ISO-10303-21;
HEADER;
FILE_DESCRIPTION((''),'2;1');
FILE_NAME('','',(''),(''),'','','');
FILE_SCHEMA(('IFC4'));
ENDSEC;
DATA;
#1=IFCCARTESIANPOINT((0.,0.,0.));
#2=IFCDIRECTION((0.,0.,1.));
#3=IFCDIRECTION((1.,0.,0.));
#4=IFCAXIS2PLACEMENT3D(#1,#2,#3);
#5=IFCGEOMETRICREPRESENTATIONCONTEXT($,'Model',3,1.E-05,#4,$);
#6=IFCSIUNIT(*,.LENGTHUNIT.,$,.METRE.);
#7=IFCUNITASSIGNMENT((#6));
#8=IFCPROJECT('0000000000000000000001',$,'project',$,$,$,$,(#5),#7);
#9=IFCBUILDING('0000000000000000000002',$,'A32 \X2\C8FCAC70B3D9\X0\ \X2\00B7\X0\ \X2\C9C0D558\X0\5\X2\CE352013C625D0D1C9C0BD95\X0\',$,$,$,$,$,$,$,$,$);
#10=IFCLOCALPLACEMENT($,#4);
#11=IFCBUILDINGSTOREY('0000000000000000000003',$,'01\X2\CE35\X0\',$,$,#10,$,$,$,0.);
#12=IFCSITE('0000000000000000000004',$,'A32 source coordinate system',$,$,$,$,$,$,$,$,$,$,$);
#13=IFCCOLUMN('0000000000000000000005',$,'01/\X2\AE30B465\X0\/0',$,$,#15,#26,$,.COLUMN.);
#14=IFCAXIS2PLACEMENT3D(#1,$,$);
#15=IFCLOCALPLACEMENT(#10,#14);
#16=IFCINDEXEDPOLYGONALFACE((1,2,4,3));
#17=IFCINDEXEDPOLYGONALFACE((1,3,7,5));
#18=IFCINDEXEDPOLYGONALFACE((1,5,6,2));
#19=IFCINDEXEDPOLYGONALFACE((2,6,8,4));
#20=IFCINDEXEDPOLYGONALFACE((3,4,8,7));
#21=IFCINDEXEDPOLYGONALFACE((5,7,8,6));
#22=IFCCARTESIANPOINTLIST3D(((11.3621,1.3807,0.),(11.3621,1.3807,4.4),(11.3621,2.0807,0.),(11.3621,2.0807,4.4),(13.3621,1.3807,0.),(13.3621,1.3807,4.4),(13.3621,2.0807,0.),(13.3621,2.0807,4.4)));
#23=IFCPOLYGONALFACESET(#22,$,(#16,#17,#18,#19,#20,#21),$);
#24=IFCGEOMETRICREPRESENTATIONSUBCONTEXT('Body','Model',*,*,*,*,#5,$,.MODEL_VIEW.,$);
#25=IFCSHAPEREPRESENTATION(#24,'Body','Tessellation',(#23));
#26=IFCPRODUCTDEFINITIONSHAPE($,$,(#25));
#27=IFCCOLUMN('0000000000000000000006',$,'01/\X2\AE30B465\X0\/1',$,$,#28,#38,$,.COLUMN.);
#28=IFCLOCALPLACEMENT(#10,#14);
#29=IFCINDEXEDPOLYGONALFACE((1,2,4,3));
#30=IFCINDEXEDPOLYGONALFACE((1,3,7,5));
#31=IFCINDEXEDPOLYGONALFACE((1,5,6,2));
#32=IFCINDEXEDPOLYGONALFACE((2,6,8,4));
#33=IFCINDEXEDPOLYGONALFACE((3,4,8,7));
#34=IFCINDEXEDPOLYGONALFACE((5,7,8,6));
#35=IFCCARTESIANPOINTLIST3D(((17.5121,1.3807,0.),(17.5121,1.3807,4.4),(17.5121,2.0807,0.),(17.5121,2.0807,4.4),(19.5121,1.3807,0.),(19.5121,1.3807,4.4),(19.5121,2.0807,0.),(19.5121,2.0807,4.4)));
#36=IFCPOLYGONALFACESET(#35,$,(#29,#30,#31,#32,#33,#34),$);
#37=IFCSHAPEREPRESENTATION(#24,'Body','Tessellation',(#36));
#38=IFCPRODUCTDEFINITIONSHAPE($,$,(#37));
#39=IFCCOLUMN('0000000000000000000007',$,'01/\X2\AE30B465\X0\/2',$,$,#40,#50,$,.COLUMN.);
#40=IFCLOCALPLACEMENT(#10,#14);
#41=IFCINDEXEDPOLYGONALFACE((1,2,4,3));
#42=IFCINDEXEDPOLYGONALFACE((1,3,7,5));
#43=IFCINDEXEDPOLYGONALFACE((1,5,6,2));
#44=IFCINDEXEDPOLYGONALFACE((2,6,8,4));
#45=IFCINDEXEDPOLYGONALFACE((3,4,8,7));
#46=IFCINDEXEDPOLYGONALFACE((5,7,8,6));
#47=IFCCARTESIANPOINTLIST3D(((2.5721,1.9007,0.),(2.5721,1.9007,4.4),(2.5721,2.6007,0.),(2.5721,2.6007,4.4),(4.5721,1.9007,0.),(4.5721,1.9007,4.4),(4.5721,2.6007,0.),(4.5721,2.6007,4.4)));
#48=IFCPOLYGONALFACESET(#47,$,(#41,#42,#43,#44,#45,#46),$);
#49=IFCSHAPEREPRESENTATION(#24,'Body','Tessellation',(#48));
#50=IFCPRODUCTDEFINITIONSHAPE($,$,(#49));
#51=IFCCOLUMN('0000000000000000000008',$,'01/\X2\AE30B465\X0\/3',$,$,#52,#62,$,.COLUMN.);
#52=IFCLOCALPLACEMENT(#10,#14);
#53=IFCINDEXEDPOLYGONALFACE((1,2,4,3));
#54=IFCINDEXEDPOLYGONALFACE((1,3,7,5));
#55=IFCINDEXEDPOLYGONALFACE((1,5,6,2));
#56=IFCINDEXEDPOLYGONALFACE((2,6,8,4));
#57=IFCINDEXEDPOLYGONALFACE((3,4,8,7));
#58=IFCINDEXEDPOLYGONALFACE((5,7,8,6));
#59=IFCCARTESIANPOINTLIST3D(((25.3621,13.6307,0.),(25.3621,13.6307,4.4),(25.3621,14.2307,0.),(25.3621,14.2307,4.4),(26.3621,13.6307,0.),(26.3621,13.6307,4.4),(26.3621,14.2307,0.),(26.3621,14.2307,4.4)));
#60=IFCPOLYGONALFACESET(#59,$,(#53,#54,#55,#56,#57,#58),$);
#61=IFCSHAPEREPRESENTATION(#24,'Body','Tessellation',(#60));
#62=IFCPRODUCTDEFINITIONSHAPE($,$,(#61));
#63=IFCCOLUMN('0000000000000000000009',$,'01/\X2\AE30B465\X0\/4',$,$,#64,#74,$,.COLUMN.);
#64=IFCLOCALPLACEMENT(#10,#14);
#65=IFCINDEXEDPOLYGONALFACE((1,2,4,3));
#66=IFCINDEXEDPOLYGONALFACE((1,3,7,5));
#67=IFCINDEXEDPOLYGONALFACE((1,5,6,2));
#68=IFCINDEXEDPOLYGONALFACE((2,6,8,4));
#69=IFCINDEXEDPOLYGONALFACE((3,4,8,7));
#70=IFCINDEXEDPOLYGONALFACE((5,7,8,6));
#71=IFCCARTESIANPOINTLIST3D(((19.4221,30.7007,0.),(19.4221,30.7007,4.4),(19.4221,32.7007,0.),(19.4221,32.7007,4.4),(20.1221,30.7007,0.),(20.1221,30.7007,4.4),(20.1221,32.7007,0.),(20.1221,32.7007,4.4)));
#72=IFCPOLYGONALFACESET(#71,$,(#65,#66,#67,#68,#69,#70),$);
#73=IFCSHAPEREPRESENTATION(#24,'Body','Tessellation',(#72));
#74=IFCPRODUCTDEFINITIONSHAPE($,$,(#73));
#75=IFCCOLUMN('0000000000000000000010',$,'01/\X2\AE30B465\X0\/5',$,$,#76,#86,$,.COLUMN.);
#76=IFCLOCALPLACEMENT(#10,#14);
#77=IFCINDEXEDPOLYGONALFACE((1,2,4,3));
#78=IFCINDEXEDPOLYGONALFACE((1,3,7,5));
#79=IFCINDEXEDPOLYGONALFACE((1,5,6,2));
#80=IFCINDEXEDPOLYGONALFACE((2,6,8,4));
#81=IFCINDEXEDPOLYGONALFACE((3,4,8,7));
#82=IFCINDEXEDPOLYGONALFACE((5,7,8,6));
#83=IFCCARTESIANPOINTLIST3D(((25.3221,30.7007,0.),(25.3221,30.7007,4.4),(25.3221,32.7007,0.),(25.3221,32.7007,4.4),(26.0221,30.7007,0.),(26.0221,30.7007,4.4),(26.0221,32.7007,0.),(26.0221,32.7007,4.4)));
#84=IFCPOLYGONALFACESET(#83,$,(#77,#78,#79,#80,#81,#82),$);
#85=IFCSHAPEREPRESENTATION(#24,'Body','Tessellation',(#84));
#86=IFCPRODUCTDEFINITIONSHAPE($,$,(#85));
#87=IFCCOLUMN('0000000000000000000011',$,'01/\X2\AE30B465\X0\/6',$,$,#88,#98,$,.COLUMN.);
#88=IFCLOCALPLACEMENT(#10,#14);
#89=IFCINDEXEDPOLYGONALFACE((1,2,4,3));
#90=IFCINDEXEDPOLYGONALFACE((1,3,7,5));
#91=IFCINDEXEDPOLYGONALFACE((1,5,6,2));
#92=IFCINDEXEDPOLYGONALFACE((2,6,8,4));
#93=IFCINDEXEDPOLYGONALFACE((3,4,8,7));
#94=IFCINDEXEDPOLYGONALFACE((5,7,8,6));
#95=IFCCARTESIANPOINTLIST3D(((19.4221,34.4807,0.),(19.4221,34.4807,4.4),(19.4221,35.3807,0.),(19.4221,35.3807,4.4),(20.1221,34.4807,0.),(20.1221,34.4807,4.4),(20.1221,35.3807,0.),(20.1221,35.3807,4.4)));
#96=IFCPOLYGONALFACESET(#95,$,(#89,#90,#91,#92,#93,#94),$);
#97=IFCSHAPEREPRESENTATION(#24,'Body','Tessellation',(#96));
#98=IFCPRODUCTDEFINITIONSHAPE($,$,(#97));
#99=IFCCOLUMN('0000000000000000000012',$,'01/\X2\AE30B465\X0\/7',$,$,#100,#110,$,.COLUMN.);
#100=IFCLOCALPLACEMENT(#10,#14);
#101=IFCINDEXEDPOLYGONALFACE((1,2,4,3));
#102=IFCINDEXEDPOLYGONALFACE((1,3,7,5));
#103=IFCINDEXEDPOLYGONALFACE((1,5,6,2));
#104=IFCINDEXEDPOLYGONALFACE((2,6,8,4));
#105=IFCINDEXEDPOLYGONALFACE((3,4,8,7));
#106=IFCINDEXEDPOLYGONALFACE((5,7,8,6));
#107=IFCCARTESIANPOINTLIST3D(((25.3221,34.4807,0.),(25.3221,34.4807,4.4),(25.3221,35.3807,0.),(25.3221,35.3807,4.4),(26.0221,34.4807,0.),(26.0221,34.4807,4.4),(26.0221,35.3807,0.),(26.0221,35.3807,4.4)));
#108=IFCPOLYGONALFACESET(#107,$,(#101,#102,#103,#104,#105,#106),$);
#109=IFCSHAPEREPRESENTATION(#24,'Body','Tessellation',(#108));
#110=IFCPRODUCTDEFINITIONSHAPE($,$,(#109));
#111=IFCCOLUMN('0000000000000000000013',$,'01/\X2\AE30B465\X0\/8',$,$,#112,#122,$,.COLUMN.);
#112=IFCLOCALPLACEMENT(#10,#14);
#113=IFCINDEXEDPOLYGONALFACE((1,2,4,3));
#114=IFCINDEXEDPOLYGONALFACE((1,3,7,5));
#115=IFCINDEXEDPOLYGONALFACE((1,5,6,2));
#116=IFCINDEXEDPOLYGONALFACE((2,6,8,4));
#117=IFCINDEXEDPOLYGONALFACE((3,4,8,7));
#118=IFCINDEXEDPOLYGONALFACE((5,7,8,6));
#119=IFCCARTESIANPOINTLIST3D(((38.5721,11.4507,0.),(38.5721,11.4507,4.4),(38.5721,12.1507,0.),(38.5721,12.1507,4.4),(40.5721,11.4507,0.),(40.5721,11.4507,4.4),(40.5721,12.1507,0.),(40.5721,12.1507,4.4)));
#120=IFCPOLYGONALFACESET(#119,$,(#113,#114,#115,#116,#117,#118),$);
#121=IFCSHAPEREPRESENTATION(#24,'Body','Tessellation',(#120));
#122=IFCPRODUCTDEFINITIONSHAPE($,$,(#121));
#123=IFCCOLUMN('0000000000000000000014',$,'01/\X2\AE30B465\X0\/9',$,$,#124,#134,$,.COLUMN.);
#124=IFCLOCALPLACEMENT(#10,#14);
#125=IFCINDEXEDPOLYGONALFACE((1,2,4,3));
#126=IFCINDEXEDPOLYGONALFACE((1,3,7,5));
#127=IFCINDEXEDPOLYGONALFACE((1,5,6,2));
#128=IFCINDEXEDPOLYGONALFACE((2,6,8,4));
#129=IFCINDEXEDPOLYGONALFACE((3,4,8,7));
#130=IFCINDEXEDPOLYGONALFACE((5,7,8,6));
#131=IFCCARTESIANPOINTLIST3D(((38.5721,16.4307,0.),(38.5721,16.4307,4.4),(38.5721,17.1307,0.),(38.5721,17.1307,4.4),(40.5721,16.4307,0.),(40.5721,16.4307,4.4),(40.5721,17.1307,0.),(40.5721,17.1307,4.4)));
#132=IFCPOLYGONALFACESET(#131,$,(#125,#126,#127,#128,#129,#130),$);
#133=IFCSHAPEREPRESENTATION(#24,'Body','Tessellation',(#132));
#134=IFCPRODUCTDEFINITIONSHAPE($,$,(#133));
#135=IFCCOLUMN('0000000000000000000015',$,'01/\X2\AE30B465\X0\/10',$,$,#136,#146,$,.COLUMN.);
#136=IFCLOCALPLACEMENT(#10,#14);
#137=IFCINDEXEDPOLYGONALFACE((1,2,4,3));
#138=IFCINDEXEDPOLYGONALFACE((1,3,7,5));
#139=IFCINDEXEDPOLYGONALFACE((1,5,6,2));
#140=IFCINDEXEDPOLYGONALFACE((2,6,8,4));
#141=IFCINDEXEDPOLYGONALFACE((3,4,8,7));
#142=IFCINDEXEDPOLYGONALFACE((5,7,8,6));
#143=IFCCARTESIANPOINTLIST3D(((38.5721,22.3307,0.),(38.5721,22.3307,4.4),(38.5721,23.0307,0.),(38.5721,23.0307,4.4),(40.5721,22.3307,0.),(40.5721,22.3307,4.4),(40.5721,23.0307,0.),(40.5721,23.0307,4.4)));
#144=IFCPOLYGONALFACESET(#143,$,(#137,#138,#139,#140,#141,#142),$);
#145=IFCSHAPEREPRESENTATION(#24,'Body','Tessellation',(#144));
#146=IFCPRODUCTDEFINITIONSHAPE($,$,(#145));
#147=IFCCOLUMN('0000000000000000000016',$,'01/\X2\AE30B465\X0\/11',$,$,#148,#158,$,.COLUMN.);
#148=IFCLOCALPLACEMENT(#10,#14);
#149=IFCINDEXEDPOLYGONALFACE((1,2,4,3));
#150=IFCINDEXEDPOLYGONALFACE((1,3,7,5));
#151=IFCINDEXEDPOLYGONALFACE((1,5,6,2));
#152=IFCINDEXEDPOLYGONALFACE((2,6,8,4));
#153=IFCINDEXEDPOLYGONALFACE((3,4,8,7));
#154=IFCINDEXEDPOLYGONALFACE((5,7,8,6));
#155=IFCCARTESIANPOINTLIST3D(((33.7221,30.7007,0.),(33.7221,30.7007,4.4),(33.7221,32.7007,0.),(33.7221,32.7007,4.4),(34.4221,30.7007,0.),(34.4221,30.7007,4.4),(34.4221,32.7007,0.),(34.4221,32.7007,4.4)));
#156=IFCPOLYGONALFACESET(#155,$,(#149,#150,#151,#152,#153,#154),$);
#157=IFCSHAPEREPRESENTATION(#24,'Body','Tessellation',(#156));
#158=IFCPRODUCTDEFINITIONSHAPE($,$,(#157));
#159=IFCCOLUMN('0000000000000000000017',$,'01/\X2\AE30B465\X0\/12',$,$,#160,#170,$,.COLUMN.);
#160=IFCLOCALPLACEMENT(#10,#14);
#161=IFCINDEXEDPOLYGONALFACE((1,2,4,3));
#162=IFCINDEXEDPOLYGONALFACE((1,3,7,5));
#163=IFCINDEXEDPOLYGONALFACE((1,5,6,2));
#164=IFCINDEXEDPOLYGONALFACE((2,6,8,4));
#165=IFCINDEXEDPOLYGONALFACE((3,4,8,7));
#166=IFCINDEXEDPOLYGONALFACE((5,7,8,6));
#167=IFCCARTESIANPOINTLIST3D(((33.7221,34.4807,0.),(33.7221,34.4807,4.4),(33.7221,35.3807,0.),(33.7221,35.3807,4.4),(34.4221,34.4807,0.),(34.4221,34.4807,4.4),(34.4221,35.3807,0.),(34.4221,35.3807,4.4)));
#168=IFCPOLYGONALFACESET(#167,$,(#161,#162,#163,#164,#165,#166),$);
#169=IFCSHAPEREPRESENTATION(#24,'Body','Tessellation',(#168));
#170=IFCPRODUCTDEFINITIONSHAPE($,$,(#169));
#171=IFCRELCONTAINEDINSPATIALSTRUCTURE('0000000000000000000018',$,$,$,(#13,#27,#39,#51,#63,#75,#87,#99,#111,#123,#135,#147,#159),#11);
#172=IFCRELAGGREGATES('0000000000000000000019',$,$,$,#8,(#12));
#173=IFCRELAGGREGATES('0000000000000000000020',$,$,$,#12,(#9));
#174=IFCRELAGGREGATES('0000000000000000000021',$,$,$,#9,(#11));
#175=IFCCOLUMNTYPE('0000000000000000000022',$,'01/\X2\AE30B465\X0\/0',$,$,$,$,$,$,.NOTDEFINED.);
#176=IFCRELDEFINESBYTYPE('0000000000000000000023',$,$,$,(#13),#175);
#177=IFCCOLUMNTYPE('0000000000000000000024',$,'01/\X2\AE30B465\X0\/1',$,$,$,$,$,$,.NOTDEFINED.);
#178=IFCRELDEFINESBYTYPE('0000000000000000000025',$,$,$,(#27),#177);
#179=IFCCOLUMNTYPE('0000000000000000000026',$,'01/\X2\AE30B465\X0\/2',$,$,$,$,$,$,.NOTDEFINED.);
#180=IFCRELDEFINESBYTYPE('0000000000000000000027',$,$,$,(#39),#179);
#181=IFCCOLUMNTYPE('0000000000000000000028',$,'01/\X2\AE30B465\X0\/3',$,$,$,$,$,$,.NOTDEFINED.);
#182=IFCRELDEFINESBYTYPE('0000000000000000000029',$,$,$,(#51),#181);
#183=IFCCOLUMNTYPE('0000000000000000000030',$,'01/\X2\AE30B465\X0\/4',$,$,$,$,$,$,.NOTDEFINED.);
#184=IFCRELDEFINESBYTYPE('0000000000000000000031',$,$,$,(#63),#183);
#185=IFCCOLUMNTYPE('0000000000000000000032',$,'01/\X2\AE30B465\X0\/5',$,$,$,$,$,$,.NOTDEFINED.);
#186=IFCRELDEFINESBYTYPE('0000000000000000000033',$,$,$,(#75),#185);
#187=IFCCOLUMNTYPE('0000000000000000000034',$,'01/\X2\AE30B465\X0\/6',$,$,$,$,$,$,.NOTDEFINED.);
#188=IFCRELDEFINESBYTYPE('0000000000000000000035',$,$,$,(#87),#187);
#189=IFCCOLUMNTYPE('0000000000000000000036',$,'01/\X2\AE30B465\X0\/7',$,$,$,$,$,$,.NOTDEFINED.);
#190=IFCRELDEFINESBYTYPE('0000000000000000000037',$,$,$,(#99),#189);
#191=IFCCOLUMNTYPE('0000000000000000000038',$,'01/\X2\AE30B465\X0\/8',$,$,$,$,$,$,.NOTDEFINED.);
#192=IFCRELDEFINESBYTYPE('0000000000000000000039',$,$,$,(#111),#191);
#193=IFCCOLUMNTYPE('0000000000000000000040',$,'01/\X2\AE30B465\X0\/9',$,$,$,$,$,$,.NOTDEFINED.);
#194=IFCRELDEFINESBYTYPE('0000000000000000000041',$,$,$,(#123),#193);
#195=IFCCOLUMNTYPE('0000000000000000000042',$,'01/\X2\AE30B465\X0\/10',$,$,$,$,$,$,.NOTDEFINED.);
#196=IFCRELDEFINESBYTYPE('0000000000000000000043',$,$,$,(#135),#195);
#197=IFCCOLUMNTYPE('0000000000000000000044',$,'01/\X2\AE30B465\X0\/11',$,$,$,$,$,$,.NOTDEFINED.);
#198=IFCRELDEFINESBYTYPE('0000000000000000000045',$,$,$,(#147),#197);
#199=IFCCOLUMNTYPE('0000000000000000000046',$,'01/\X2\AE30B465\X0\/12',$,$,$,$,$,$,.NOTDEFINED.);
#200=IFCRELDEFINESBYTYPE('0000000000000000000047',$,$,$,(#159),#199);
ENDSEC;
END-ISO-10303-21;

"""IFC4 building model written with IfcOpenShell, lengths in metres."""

from ifc_helpers import new_model, si_unit, origin, origin_with_axes, place, context, subcontext, project, spatial, polyline, outline, extrude, source, transform, mapped, type_object, type_shapes, element, save


model = new_model("IFC4")

# Units and contexts
model_context = context("Model", 3, precision=1e-05, world=origin_with_axes())
body_context = subcontext(model_context, "Body", "Model", "MODEL_VIEW")
ifc_project = project(units=[si_unit("LENGTHUNIT", "METRE")], contexts=[model_context])

# Site, building, storey
site = spatial("IfcSite", under=ifc_project, Name="A32 source coordinate system")
building = spatial("IfcBuilding", under=site, Name="A32 주거동 · 지하5층–옥탑지붕")
storey_placement = place(None, origin_with_axes())
storey = spatial("IfcBuildingStorey", under=building, at=storey_placement, Name="01층", Elevation=0.0)

# Columns
column_type_1 = type_object("IfcColumnType", Name="01/기둥/0", PredefinedType="NOTDEFINED")
shared_shape_1 = source(origin(), body_context, "Body", "SweptSolid", [
    extrude(outline(polyline([(13.3621, 2.0807), (13.3621, 1.3807), (11.3621, 1.3807), (11.3621, 2.0807), (13.3621, 2.0807)])), origin(), (0.0, 0.0, 1.0), 4.4),
])
type_shapes(column_type_1, [shared_shape_1])
column_1_placement = place(storey_placement, origin_with_axes())
element("IfcColumn", 1, at=column_1_placement, inside=storey, type_object=column_type_1, Name="01/기둥/0", PredefinedType="COLUMN", context=body_context, shape_type="MappedRepresentation", body=[
    mapped(shared_shape_1, transform((0.0, 0.0, 0.0), scale=1.0)),
])
column_type_2 = type_object("IfcColumnType", Name="01/기둥/1", PredefinedType="NOTDEFINED")
shared_shape_2 = source(origin(), body_context, "Body", "SweptSolid", [
    extrude(outline(polyline([(19.5121, 2.0807), (19.5121, 1.3807), (17.5121, 1.3807), (17.5121, 2.0807), (19.5121, 2.0807)])), origin(), (0.0, 0.0, 1.0), 4.4),
])
type_shapes(column_type_2, [shared_shape_2])
column_2_placement = place(storey_placement, origin_with_axes())
element("IfcColumn", 2, at=column_2_placement, inside=storey, type_object=column_type_2, Name="01/기둥/1", PredefinedType="COLUMN", context=body_context, shape_type="MappedRepresentation", body=[
    mapped(shared_shape_2, transform((0.0, 0.0, 0.0), scale=1.0)),
])
column_type_3 = type_object("IfcColumnType", Name="01/기둥/2", PredefinedType="NOTDEFINED")
shared_shape_3 = source(origin(), body_context, "Body", "SweptSolid", [
    extrude(outline(polyline([(4.5721, 1.9007), (2.5721, 1.9007), (2.5721, 2.6007), (4.5721, 2.6007), (4.5721, 1.9007)])), origin(), (0.0, 0.0, 1.0), 4.4),
])
type_shapes(column_type_3, [shared_shape_3])
column_3_placement = place(storey_placement, origin_with_axes())
element("IfcColumn", 3, at=column_3_placement, inside=storey, type_object=column_type_3, Name="01/기둥/2", PredefinedType="COLUMN", context=body_context, shape_type="MappedRepresentation", body=[
    mapped(shared_shape_3, transform((0.0, 0.0, 0.0), scale=1.0)),
])
column_type_4 = type_object("IfcColumnType", Name="01/기둥/3", PredefinedType="NOTDEFINED")
shared_shape_4 = source(origin(), body_context, "Body", "SweptSolid", [
    extrude(outline(polyline([(26.3621, 13.6307), (25.3621, 13.6307), (25.3621, 14.2307), (26.3621, 14.2307), (26.3621, 13.6307)])), origin(), (0.0, 0.0, 1.0), 4.4),
])
type_shapes(column_type_4, [shared_shape_4])
column_4_placement = place(storey_placement, origin_with_axes())
element("IfcColumn", 4, at=column_4_placement, inside=storey, type_object=column_type_4, Name="01/기둥/3", PredefinedType="COLUMN", context=body_context, shape_type="MappedRepresentation", body=[
    mapped(shared_shape_4, transform((0.0, 0.0, 0.0), scale=1.0)),
])
column_type_5 = type_object("IfcColumnType", Name="01/기둥/4", PredefinedType="NOTDEFINED")
shared_shape_5 = source(origin(), body_context, "Body", "SweptSolid", [
    extrude(outline(polyline([(20.1221, 30.7007), (19.4221, 30.7007), (19.4221, 32.7007), (20.1221, 32.7007), (20.1221, 30.7007)])), origin(), (0.0, 0.0, 1.0), 4.4),
])
type_shapes(column_type_5, [shared_shape_5])
column_5_placement = place(storey_placement, origin_with_axes())
element("IfcColumn", 5, at=column_5_placement, inside=storey, type_object=column_type_5, Name="01/기둥/4", PredefinedType="COLUMN", context=body_context, shape_type="MappedRepresentation", body=[
    mapped(shared_shape_5, transform((0.0, 0.0, 0.0), scale=1.0)),
])
column_type_6 = type_object("IfcColumnType", Name="01/기둥/5", PredefinedType="NOTDEFINED")
shared_shape_6 = source(origin(), body_context, "Body", "SweptSolid", [
    extrude(outline(polyline([(26.0221, 32.7007), (26.0221, 30.7007), (25.3221, 30.7007), (25.3221, 32.7007), (26.0221, 32.7007)])), origin(), (0.0, 0.0, 1.0), 4.4),
])
type_shapes(column_type_6, [shared_shape_6])
column_6_placement = place(storey_placement, origin_with_axes())
element("IfcColumn", 6, at=column_6_placement, inside=storey, type_object=column_type_6, Name="01/기둥/5", PredefinedType="COLUMN", context=body_context, shape_type="MappedRepresentation", body=[
    mapped(shared_shape_6, transform((0.0, 0.0, 0.0), scale=1.0)),
])
column_type_7 = type_object("IfcColumnType", Name="01/기둥/6", PredefinedType="NOTDEFINED")
shared_shape_7 = source(origin(), body_context, "Body", "SweptSolid", [
    extrude(outline(polyline([(20.1221, 34.4807), (19.4221, 34.4807), (19.4221, 35.3807), (20.1221, 35.3807), (20.1221, 34.4807)])), origin(), (0.0, 0.0, 1.0), 4.4),
])
type_shapes(column_type_7, [shared_shape_7])
column_7_placement = place(storey_placement, origin_with_axes())
element("IfcColumn", 7, at=column_7_placement, inside=storey, type_object=column_type_7, Name="01/기둥/6", PredefinedType="COLUMN", context=body_context, shape_type="MappedRepresentation", body=[
    mapped(shared_shape_7, transform((0.0, 0.0, 0.0), scale=1.0)),
])
column_type_8 = type_object("IfcColumnType", Name="01/기둥/7", PredefinedType="NOTDEFINED")
shared_shape_8 = source(origin(), body_context, "Body", "SweptSolid", [
    extrude(outline(polyline([(26.0221, 35.3807), (26.0221, 34.4807), (25.3221, 34.4807), (25.3221, 35.3807), (26.0221, 35.3807)])), origin(), (0.0, 0.0, 1.0), 4.4),
])
type_shapes(column_type_8, [shared_shape_8])
column_8_placement = place(storey_placement, origin_with_axes())
element("IfcColumn", 8, at=column_8_placement, inside=storey, type_object=column_type_8, Name="01/기둥/7", PredefinedType="COLUMN", context=body_context, shape_type="MappedRepresentation", body=[
    mapped(shared_shape_8, transform((0.0, 0.0, 0.0), scale=1.0)),
])
column_type_9 = type_object("IfcColumnType", Name="01/기둥/8", PredefinedType="NOTDEFINED")
shared_shape_9 = source(origin(), body_context, "Body", "SweptSolid", [
    extrude(outline(polyline([(40.5721, 12.1507), (40.5721, 11.4507), (38.5721, 11.4507), (38.5721, 12.1507), (40.5721, 12.1507)])), origin(), (0.0, 0.0, 1.0), 4.4),
])
type_shapes(column_type_9, [shared_shape_9])
column_9_placement = place(storey_placement, origin_with_axes())
element("IfcColumn", 9, at=column_9_placement, inside=storey, type_object=column_type_9, Name="01/기둥/8", PredefinedType="COLUMN", context=body_context, shape_type="MappedRepresentation", body=[
    mapped(shared_shape_9, transform((0.0, 0.0, 0.0), scale=1.0)),
])
column_type_10 = type_object("IfcColumnType", Name="01/기둥/9", PredefinedType="NOTDEFINED")
shared_shape_10 = source(origin(), body_context, "Body", "SweptSolid", [
    extrude(outline(polyline([(40.5721, 16.4307), (38.5721, 16.4307), (38.5721, 17.1307), (40.5721, 17.1307), (40.5721, 16.4307)])), origin(), (0.0, 0.0, 1.0), 4.4),
])
type_shapes(column_type_10, [shared_shape_10])
column_10_placement = place(storey_placement, origin_with_axes())
element("IfcColumn", 10, at=column_10_placement, inside=storey, type_object=column_type_10, Name="01/기둥/9", PredefinedType="COLUMN", context=body_context, shape_type="MappedRepresentation", body=[
    mapped(shared_shape_10, transform((0.0, 0.0, 0.0), scale=1.0)),
])
column_type_11 = type_object("IfcColumnType", Name="01/기둥/10", PredefinedType="NOTDEFINED")
shared_shape_11 = source(origin(), body_context, "Body", "SweptSolid", [
    extrude(outline(polyline([(40.5721, 23.0307), (40.5721, 22.3307), (38.5721, 22.3307), (38.5721, 23.0307), (40.5721, 23.0307)])), origin(), (0.0, 0.0, 1.0), 4.4),
])
type_shapes(column_type_11, [shared_shape_11])
column_11_placement = place(storey_placement, origin_with_axes())
element("IfcColumn", 11, at=column_11_placement, inside=storey, type_object=column_type_11, Name="01/기둥/10", PredefinedType="COLUMN", context=body_context, shape_type="MappedRepresentation", body=[
    mapped(shared_shape_11, transform((0.0, 0.0, 0.0), scale=1.0)),
])
column_type_12 = type_object("IfcColumnType", Name="01/기둥/11", PredefinedType="NOTDEFINED")
shared_shape_12 = source(origin(), body_context, "Body", "SweptSolid", [
    extrude(outline(polyline([(34.4221, 32.7007), (34.4221, 30.7007), (33.7221, 30.7007), (33.7221, 32.7007), (34.4221, 32.7007)])), origin(), (0.0, 0.0, 1.0), 4.4),
])
type_shapes(column_type_12, [shared_shape_12])
column_12_placement = place(storey_placement, origin_with_axes())
element("IfcColumn", 12, at=column_12_placement, inside=storey, type_object=column_type_12, Name="01/기둥/11", PredefinedType="COLUMN", context=body_context, shape_type="MappedRepresentation", body=[
    mapped(shared_shape_12, transform((0.0, 0.0, 0.0), scale=1.0)),
])
column_type_13 = type_object("IfcColumnType", Name="01/기둥/12", PredefinedType="NOTDEFINED")
shared_shape_13 = source(origin(), body_context, "Body", "SweptSolid", [
    extrude(outline(polyline([(34.4221, 34.4807), (33.7221, 34.4807), (33.7221, 35.3807), (34.4221, 35.3807), (34.4221, 34.4807)])), origin(), (0.0, 0.0, 1.0), 4.4),
])
type_shapes(column_type_13, [shared_shape_13])
column_13_placement = place(storey_placement, origin_with_axes())
element("IfcColumn", 13, at=column_13_placement, inside=storey, type_object=column_type_13, Name="01/기둥/12", PredefinedType="COLUMN", context=body_context, shape_type="MappedRepresentation", body=[
    mapped(shared_shape_13, transform((0.0, 0.0, 0.0), scale=1.0)),
])

save(model, "model.ifc")
